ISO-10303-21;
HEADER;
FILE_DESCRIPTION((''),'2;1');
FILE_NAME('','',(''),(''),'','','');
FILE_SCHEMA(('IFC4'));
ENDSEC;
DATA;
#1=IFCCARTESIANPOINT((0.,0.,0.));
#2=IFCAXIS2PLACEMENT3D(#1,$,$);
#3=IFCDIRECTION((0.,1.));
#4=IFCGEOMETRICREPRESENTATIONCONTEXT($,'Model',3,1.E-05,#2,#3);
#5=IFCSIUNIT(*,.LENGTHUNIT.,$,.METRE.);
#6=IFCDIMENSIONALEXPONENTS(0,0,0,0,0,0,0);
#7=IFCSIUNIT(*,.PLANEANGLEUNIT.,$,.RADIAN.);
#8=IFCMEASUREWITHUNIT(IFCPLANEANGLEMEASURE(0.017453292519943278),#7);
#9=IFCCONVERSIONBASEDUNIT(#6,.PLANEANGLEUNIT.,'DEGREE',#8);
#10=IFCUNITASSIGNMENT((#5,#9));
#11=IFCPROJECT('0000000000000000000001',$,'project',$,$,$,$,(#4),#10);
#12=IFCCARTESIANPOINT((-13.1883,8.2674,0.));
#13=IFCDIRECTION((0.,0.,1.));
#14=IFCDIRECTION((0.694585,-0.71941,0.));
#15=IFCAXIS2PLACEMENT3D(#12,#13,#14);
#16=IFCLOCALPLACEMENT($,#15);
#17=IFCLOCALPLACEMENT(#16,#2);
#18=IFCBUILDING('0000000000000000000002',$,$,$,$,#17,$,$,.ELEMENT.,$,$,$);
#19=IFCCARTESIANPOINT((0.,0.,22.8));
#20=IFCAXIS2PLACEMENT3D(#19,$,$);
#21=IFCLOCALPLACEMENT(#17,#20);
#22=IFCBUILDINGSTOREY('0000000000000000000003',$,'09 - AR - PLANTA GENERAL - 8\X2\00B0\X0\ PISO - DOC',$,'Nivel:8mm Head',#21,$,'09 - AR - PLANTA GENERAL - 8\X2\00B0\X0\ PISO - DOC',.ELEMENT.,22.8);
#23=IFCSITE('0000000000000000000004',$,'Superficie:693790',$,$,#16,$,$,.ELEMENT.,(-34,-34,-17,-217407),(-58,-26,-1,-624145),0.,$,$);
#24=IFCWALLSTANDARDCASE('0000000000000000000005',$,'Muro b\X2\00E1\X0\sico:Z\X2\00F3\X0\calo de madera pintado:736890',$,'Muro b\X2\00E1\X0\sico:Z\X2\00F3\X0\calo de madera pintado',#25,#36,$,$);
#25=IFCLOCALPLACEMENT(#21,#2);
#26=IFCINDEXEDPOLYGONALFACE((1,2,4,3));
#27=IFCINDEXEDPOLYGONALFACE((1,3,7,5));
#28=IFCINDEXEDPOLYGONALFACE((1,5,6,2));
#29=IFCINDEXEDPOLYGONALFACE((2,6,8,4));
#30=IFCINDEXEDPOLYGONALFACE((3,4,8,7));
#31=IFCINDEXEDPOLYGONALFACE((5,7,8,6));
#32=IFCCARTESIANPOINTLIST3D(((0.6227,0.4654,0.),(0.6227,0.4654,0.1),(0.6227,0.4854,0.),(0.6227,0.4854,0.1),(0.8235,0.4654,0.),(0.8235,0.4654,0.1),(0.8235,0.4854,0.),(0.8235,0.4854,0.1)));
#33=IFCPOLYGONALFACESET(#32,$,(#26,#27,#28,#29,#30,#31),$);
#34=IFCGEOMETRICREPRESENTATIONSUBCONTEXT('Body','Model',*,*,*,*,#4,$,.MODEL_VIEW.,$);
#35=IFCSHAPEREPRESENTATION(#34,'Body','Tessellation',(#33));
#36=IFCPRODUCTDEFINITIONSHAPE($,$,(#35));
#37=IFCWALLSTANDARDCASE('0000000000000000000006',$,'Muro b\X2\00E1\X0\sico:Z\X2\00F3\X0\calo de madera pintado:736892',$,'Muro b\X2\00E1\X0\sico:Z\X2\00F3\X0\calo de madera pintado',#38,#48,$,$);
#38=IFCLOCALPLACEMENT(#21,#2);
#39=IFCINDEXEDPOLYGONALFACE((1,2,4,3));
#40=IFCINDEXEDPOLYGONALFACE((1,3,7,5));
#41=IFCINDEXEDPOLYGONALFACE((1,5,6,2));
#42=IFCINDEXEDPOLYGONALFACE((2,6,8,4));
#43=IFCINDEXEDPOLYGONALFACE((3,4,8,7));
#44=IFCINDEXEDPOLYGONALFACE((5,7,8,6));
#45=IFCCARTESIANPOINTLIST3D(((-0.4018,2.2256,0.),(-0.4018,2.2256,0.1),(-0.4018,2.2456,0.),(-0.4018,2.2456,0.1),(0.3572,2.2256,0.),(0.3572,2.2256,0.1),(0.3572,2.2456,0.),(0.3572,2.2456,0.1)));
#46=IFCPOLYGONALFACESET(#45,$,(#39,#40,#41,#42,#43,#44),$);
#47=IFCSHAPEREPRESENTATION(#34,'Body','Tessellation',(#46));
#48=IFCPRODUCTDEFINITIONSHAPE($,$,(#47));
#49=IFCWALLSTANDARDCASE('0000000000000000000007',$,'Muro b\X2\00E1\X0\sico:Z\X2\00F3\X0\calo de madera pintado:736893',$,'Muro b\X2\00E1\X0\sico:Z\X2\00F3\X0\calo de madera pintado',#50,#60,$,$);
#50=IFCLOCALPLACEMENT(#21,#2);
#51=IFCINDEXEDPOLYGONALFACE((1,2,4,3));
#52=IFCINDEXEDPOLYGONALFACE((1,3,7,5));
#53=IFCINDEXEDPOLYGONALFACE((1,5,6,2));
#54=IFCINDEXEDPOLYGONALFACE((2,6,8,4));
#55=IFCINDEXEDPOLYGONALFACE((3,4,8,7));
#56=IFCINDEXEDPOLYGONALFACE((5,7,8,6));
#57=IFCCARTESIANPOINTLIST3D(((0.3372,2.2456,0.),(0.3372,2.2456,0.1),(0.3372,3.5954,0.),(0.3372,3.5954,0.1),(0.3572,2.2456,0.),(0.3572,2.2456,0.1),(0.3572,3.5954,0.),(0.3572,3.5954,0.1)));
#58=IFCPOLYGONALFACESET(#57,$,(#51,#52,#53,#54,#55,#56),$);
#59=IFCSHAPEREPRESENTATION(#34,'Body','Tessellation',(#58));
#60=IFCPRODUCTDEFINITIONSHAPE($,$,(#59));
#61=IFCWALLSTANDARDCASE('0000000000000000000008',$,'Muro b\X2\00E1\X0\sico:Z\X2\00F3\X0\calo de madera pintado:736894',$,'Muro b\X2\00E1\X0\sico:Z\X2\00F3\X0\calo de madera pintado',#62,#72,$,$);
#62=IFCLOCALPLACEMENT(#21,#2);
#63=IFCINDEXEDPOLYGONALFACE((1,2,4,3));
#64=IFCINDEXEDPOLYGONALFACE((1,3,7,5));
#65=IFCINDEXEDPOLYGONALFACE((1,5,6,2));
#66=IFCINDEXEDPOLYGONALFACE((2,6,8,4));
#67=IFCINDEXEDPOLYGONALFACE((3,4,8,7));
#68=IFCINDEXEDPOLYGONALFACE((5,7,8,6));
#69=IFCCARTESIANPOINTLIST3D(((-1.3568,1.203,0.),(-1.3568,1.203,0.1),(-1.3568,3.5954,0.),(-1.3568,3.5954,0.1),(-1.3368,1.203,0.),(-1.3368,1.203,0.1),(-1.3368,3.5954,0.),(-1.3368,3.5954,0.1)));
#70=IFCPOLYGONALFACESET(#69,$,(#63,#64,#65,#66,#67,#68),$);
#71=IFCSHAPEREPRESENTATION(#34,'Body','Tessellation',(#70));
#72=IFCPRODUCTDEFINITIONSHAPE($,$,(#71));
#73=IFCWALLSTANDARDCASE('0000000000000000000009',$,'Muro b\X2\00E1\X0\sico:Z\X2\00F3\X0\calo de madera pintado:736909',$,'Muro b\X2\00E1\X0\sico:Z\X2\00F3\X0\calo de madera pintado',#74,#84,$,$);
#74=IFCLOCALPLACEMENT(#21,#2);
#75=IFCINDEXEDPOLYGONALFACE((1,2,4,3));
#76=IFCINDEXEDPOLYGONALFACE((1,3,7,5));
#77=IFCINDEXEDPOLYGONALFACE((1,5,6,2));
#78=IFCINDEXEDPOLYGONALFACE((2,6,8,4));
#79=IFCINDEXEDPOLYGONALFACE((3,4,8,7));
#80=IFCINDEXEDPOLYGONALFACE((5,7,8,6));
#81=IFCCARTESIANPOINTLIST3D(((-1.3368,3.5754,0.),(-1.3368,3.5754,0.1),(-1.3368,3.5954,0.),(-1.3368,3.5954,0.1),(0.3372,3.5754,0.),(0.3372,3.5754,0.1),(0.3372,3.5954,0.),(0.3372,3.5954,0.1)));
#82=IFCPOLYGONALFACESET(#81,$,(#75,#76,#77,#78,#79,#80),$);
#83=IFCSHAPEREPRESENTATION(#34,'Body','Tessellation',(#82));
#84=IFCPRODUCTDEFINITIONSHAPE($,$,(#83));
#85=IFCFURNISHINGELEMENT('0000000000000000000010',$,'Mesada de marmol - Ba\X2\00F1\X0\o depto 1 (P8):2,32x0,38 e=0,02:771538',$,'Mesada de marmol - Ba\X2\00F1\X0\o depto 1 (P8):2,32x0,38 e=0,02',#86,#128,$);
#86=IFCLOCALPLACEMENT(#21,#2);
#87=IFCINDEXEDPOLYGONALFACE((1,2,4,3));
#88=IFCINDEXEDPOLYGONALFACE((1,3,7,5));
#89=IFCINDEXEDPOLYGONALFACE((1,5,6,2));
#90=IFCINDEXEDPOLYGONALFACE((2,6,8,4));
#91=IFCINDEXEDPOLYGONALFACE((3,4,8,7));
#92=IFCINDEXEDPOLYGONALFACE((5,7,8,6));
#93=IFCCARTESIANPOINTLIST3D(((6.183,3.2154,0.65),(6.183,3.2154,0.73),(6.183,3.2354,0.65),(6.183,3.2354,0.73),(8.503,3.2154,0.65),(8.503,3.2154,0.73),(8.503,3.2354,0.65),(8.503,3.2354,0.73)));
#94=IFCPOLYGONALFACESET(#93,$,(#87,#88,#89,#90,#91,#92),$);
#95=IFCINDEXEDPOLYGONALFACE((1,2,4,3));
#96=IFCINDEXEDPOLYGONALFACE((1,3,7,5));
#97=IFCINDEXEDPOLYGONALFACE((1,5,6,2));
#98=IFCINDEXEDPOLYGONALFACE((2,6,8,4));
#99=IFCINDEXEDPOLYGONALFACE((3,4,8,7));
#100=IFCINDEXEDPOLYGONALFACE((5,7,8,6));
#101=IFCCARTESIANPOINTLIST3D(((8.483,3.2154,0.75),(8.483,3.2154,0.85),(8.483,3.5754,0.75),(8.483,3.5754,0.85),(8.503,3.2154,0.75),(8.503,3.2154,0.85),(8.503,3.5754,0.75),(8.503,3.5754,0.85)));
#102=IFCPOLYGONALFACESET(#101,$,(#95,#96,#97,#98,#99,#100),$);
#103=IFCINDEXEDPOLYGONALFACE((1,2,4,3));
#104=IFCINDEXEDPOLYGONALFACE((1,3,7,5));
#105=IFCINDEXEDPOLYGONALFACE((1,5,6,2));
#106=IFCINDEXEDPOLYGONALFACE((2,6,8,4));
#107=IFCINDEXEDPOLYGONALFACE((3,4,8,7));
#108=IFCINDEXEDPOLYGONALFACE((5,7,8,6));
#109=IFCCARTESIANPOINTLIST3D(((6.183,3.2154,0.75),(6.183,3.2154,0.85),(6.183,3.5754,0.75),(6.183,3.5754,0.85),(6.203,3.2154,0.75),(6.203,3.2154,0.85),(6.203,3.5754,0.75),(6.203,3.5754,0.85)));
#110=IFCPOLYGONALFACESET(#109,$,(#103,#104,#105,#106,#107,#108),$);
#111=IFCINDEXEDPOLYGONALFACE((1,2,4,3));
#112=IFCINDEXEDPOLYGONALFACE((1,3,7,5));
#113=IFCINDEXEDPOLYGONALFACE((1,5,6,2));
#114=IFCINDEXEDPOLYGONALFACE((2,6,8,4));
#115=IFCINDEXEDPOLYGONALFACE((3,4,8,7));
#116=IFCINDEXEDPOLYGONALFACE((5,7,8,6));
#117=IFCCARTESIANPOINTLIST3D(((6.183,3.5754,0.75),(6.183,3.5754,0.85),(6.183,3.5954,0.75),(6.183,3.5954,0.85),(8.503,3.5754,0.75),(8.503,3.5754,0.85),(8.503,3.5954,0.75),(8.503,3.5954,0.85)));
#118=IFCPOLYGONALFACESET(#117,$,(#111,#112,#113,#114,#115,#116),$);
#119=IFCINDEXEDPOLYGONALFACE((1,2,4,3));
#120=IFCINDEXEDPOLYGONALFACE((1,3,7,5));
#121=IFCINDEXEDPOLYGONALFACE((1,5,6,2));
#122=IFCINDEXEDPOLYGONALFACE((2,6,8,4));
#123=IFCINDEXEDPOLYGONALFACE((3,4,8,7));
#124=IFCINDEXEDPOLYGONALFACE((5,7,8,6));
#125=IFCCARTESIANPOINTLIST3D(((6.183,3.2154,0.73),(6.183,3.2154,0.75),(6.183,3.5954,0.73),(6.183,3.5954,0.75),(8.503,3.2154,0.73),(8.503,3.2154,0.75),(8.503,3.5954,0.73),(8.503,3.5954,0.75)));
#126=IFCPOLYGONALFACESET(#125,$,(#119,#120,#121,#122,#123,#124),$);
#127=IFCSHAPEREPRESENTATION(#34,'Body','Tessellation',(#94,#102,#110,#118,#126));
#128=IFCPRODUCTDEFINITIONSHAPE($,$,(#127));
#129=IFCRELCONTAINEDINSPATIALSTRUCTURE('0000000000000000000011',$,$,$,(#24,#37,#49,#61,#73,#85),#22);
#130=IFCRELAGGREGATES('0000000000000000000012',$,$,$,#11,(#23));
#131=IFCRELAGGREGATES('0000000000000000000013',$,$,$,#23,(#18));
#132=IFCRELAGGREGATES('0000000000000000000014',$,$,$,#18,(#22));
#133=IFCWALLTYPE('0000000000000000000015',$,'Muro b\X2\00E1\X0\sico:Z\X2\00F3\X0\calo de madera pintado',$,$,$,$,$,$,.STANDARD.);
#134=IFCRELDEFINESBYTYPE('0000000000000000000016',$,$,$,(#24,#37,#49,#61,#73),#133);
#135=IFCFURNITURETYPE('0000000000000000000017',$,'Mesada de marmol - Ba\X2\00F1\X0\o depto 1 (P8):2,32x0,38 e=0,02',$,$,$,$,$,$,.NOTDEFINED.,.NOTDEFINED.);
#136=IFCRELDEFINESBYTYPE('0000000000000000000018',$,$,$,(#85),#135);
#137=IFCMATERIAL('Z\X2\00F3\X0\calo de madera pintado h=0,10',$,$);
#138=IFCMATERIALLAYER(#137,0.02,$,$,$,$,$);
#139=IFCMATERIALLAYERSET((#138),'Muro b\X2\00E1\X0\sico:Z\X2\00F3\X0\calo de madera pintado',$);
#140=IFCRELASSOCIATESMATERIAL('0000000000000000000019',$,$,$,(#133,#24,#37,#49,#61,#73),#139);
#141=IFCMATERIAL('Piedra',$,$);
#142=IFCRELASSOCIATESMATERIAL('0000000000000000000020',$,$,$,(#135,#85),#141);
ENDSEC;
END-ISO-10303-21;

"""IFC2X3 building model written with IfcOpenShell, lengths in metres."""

from ifc_helpers import new_model, entity, si_unit, converted_unit, direction, frame, frame_2d, origin, origin_2d_with_axis, place, context, subcontext, project, spatial, rectangle, extrude, source, transform, mapped, material, layer, layer_set, layer_usage, type_object, type_shapes, element, save


model = new_model("IFC2X3")

# Units and contexts
model_context = context("Model", 3, precision=1e-05, world=origin(), true_north=direction((0.0, 1.0)))
body_context = subcontext(model_context, "Body", "Model", "MODEL_VIEW")
ifc_project = project(units=[si_unit("LENGTHUNIT", "METRE"), converted_unit("PLANEANGLEUNIT", "DEGREE", entity("IfcPlaneAngleMeasure", 0.017453292519943278), si_unit("PLANEANGLEUNIT", "RADIAN"), dimensions=[0, 0, 0, 0, 0, 0, 0])], contexts=[model_context])

# Site, building, storey
site_placement = place(None, frame((-13.1883, 8.2674, 0.0), z_axis=(0.0, 0.0, 1.0), x_axis=(0.694585, -0.71941, 0.0)))
site = spatial("IfcSite", under=ifc_project, at=site_placement, Name="Superficie:693790", CompositionType="ELEMENT", RefLatitude=(-34, -34, -17, -217407), RefLongitude=(-58, -26, -1, -624145), RefElevation=0.0)
building_placement = place(site_placement, origin())
building = spatial("IfcBuilding", under=site, at=building_placement, CompositionType="ELEMENT")
storey_placement = place(building_placement, frame((0.0, 0.0, 22.8)))
storey = spatial("IfcBuildingStorey", under=building, at=storey_placement, Name="09 - AR - PLANTA GENERAL - 8° PISO - DOC", ObjectType="Nivel:8mm Head", LongName="09 - AR - PLANTA GENERAL - 8° PISO - DOC", CompositionType="ELEMENT", Elevation=22.8)

# Walls
ifc_material_1 = material(Name="Zócalo de madera pintado h=0,10")
ifc_layer_1 = layer(ifc_material_1, 0.02)
ifc_layer_set_1 = layer_set([ifc_layer_1], Name="Muro básico:Zócalo de madera pintado")
wall_type_1 = type_object("IfcWallType", Name="Muro básico:Zócalo de madera pintado", PredefinedType="STANDARD", material=ifc_layer_set_1)
ifc_layer_usage_1 = layer_usage(ifc_layer_set_1, "AXIS2", "NEGATIVE", 0.01)
wall_1_placement = place(storey_placement, frame((0.8235, 0.4754, 0.0), z_axis=(0.0, 0.0, 1.0), x_axis=(-1.0, 0.0, 0.0)))
element("IfcWallStandardCase", 1, at=wall_1_placement, inside=storey, type_object=wall_type_1, material=ifc_layer_usage_1, Name="Muro básico:Zócalo de madera pintado:736890", ObjectType="Muro básico:Zócalo de madera pintado", context=body_context, shape_type="SweptSolid", body=[
    extrude(rectangle(XDim=0.2008, YDim=0.02, at=frame_2d((0.1004, 0.0), x_axis=(-1.0, 0.0))), origin(), (0.0, 0.0, 1.0), 0.1),
])
ifc_layer_usage_2 = layer_usage(ifc_layer_set_1, "AXIS2", "NEGATIVE", 0.01)
wall_2_placement = place(storey_placement, frame((-0.4018, 2.2356, 0.0)))
element("IfcWallStandardCase", 2, at=wall_2_placement, inside=storey, type_object=wall_type_1, material=ifc_layer_usage_2, Name="Muro básico:Zócalo de madera pintado:736892", ObjectType="Muro básico:Zócalo de madera pintado", context=body_context, shape_type="SweptSolid", body=[
    extrude(rectangle(XDim=0.759, YDim=0.02, at=frame_2d((0.3795, 0.0), x_axis=(-1.0, 0.0))), origin(), (0.0, 0.0, 1.0), 0.1),
])
ifc_layer_usage_3 = layer_usage(ifc_layer_set_1, "AXIS2", "NEGATIVE", 0.01)
wall_3_placement = place(storey_placement, frame((0.3472, 2.2456, 0.0), z_axis=(0.0, 0.0, 1.0), x_axis=(0.0, 1.0, 0.0)))
element("IfcWallStandardCase", 3, at=wall_3_placement, inside=storey, type_object=wall_type_1, material=ifc_layer_usage_3, Name="Muro básico:Zócalo de madera pintado:736893", ObjectType="Muro básico:Zócalo de madera pintado", context=body_context, shape_type="SweptSolid", body=[
    extrude(rectangle(XDim=1.3498, YDim=0.02, at=frame_2d((0.6749, 0.0), x_axis=(-1.0, 0.0))), origin(), (0.0, 0.0, 1.0), 0.1),
])
ifc_layer_usage_4 = layer_usage(ifc_layer_set_1, "AXIS2", "NEGATIVE", 0.01)
wall_4_placement = place(storey_placement, frame((-1.3468, 3.5954, 0.0), z_axis=(0.0, 0.0, 1.0), x_axis=(0.0, -1.0, 0.0)))
element("IfcWallStandardCase", 4, at=wall_4_placement, inside=storey, type_object=wall_type_1, material=ifc_layer_usage_4, Name="Muro básico:Zócalo de madera pintado:736894", ObjectType="Muro básico:Zócalo de madera pintado", context=body_context, shape_type="SweptSolid", body=[
    extrude(rectangle(XDim=2.3924, YDim=0.02, at=frame_2d((1.1962, 0.0), x_axis=(-1.0, 0.0))), origin(), (0.0, 0.0, 1.0), 0.1),
])
ifc_layer_usage_5 = layer_usage(ifc_layer_set_1, "AXIS2", "NEGATIVE", 0.01)
wall_5_placement = place(storey_placement, frame((0.3372, 3.5854, 0.0), z_axis=(0.0, 0.0, 1.0), x_axis=(-1.0, 0.0, 0.0)))
element("IfcWallStandardCase", 5, at=wall_5_placement, inside=storey, type_object=wall_type_1, material=ifc_layer_usage_5, Name="Muro básico:Zócalo de madera pintado:736909", ObjectType="Muro básico:Zócalo de madera pintado", context=body_context, shape_type="SweptSolid", body=[
    extrude(rectangle(XDim=1.674, YDim=0.02, at=frame_2d((0.837, 0.0), x_axis=(-1.0, 0.0))), origin(), (0.0, 0.0, 1.0), 0.1),
])

# Furnishing element
ifc_material_2 = material(Name="Piedra")
furniture_type_1 = type_object("IfcFurnitureType", Name="Mesada de marmol - Baño depto 1 (P8):2,32x0,38 e=0,02", AssemblyPlace="NOTDEFINED", material=ifc_material_2)
shared_shape_1 = source(origin(), body_context, "Body", "SweptSolid", [
    extrude(rectangle(XDim=0.02, YDim=2.32, at=frame_2d((0.0, 0.0), x_axis=(1.0, 0.0))), frame((-0.0405, -0.37, 0.65), z_axis=(0.0, 0.0, 1.0), x_axis=(0.0, 1.0, 0.0)), (0.0, 0.0, 1.0), 0.08),
    extrude(rectangle(XDim=0.36, YDim=0.02, at=origin_2d_with_axis()), frame((1.1095, -0.2, 0.75), z_axis=(0.0, 0.0, 1.0), x_axis=(0.0, 1.0, 0.0)), (0.0, 0.0, 1.0), 0.1),
    extrude(rectangle(XDim=0.02, YDim=0.36, at=origin_2d_with_axis()), frame((-1.1905, -0.2, 0.75), z_axis=(0.0, 0.0, 1.0), x_axis=(-1.0, 0.0, 0.0)), (0.0, 0.0, 1.0), 0.1),
    extrude(rectangle(XDim=0.02, YDim=2.32, at=origin_2d_with_axis()), frame((-0.0405, -0.01, 0.75), z_axis=(0.0, 0.0, 1.0), x_axis=(0.0, -1.0, 0.0)), (0.0, 0.0, 1.0), 0.1),
    extrude(rectangle(XDim=2.32, YDim=0.38, at=origin_2d_with_axis()), frame((-0.0405, -0.19, 0.73), z_axis=(0.0, 0.0, 1.0), x_axis=(-1.0, 0.0, 0.0)), (0.0, 0.0, 1.0), 0.02),
])
type_shapes(furniture_type_1, [shared_shape_1])
furnishing_1_placement = place(storey_placement, frame((7.3835, 3.5954, 0.0)))
element("IfcFurnishingElement", 6, at=furnishing_1_placement, inside=storey, type_object=furniture_type_1, material=ifc_material_2, Name="Mesada de marmol - Baño depto 1 (P8):2,32x0,38 e=0,02:771538", ObjectType="Mesada de marmol - Baño depto 1 (P8):2,32x0,38 e=0,02", context=body_context, shape_type="MappedRepresentation", body=[
    mapped(shared_shape_1, transform((0.0, 0.0, 0.0), scale=1.0)),
])

save(model, "model.ifc")
